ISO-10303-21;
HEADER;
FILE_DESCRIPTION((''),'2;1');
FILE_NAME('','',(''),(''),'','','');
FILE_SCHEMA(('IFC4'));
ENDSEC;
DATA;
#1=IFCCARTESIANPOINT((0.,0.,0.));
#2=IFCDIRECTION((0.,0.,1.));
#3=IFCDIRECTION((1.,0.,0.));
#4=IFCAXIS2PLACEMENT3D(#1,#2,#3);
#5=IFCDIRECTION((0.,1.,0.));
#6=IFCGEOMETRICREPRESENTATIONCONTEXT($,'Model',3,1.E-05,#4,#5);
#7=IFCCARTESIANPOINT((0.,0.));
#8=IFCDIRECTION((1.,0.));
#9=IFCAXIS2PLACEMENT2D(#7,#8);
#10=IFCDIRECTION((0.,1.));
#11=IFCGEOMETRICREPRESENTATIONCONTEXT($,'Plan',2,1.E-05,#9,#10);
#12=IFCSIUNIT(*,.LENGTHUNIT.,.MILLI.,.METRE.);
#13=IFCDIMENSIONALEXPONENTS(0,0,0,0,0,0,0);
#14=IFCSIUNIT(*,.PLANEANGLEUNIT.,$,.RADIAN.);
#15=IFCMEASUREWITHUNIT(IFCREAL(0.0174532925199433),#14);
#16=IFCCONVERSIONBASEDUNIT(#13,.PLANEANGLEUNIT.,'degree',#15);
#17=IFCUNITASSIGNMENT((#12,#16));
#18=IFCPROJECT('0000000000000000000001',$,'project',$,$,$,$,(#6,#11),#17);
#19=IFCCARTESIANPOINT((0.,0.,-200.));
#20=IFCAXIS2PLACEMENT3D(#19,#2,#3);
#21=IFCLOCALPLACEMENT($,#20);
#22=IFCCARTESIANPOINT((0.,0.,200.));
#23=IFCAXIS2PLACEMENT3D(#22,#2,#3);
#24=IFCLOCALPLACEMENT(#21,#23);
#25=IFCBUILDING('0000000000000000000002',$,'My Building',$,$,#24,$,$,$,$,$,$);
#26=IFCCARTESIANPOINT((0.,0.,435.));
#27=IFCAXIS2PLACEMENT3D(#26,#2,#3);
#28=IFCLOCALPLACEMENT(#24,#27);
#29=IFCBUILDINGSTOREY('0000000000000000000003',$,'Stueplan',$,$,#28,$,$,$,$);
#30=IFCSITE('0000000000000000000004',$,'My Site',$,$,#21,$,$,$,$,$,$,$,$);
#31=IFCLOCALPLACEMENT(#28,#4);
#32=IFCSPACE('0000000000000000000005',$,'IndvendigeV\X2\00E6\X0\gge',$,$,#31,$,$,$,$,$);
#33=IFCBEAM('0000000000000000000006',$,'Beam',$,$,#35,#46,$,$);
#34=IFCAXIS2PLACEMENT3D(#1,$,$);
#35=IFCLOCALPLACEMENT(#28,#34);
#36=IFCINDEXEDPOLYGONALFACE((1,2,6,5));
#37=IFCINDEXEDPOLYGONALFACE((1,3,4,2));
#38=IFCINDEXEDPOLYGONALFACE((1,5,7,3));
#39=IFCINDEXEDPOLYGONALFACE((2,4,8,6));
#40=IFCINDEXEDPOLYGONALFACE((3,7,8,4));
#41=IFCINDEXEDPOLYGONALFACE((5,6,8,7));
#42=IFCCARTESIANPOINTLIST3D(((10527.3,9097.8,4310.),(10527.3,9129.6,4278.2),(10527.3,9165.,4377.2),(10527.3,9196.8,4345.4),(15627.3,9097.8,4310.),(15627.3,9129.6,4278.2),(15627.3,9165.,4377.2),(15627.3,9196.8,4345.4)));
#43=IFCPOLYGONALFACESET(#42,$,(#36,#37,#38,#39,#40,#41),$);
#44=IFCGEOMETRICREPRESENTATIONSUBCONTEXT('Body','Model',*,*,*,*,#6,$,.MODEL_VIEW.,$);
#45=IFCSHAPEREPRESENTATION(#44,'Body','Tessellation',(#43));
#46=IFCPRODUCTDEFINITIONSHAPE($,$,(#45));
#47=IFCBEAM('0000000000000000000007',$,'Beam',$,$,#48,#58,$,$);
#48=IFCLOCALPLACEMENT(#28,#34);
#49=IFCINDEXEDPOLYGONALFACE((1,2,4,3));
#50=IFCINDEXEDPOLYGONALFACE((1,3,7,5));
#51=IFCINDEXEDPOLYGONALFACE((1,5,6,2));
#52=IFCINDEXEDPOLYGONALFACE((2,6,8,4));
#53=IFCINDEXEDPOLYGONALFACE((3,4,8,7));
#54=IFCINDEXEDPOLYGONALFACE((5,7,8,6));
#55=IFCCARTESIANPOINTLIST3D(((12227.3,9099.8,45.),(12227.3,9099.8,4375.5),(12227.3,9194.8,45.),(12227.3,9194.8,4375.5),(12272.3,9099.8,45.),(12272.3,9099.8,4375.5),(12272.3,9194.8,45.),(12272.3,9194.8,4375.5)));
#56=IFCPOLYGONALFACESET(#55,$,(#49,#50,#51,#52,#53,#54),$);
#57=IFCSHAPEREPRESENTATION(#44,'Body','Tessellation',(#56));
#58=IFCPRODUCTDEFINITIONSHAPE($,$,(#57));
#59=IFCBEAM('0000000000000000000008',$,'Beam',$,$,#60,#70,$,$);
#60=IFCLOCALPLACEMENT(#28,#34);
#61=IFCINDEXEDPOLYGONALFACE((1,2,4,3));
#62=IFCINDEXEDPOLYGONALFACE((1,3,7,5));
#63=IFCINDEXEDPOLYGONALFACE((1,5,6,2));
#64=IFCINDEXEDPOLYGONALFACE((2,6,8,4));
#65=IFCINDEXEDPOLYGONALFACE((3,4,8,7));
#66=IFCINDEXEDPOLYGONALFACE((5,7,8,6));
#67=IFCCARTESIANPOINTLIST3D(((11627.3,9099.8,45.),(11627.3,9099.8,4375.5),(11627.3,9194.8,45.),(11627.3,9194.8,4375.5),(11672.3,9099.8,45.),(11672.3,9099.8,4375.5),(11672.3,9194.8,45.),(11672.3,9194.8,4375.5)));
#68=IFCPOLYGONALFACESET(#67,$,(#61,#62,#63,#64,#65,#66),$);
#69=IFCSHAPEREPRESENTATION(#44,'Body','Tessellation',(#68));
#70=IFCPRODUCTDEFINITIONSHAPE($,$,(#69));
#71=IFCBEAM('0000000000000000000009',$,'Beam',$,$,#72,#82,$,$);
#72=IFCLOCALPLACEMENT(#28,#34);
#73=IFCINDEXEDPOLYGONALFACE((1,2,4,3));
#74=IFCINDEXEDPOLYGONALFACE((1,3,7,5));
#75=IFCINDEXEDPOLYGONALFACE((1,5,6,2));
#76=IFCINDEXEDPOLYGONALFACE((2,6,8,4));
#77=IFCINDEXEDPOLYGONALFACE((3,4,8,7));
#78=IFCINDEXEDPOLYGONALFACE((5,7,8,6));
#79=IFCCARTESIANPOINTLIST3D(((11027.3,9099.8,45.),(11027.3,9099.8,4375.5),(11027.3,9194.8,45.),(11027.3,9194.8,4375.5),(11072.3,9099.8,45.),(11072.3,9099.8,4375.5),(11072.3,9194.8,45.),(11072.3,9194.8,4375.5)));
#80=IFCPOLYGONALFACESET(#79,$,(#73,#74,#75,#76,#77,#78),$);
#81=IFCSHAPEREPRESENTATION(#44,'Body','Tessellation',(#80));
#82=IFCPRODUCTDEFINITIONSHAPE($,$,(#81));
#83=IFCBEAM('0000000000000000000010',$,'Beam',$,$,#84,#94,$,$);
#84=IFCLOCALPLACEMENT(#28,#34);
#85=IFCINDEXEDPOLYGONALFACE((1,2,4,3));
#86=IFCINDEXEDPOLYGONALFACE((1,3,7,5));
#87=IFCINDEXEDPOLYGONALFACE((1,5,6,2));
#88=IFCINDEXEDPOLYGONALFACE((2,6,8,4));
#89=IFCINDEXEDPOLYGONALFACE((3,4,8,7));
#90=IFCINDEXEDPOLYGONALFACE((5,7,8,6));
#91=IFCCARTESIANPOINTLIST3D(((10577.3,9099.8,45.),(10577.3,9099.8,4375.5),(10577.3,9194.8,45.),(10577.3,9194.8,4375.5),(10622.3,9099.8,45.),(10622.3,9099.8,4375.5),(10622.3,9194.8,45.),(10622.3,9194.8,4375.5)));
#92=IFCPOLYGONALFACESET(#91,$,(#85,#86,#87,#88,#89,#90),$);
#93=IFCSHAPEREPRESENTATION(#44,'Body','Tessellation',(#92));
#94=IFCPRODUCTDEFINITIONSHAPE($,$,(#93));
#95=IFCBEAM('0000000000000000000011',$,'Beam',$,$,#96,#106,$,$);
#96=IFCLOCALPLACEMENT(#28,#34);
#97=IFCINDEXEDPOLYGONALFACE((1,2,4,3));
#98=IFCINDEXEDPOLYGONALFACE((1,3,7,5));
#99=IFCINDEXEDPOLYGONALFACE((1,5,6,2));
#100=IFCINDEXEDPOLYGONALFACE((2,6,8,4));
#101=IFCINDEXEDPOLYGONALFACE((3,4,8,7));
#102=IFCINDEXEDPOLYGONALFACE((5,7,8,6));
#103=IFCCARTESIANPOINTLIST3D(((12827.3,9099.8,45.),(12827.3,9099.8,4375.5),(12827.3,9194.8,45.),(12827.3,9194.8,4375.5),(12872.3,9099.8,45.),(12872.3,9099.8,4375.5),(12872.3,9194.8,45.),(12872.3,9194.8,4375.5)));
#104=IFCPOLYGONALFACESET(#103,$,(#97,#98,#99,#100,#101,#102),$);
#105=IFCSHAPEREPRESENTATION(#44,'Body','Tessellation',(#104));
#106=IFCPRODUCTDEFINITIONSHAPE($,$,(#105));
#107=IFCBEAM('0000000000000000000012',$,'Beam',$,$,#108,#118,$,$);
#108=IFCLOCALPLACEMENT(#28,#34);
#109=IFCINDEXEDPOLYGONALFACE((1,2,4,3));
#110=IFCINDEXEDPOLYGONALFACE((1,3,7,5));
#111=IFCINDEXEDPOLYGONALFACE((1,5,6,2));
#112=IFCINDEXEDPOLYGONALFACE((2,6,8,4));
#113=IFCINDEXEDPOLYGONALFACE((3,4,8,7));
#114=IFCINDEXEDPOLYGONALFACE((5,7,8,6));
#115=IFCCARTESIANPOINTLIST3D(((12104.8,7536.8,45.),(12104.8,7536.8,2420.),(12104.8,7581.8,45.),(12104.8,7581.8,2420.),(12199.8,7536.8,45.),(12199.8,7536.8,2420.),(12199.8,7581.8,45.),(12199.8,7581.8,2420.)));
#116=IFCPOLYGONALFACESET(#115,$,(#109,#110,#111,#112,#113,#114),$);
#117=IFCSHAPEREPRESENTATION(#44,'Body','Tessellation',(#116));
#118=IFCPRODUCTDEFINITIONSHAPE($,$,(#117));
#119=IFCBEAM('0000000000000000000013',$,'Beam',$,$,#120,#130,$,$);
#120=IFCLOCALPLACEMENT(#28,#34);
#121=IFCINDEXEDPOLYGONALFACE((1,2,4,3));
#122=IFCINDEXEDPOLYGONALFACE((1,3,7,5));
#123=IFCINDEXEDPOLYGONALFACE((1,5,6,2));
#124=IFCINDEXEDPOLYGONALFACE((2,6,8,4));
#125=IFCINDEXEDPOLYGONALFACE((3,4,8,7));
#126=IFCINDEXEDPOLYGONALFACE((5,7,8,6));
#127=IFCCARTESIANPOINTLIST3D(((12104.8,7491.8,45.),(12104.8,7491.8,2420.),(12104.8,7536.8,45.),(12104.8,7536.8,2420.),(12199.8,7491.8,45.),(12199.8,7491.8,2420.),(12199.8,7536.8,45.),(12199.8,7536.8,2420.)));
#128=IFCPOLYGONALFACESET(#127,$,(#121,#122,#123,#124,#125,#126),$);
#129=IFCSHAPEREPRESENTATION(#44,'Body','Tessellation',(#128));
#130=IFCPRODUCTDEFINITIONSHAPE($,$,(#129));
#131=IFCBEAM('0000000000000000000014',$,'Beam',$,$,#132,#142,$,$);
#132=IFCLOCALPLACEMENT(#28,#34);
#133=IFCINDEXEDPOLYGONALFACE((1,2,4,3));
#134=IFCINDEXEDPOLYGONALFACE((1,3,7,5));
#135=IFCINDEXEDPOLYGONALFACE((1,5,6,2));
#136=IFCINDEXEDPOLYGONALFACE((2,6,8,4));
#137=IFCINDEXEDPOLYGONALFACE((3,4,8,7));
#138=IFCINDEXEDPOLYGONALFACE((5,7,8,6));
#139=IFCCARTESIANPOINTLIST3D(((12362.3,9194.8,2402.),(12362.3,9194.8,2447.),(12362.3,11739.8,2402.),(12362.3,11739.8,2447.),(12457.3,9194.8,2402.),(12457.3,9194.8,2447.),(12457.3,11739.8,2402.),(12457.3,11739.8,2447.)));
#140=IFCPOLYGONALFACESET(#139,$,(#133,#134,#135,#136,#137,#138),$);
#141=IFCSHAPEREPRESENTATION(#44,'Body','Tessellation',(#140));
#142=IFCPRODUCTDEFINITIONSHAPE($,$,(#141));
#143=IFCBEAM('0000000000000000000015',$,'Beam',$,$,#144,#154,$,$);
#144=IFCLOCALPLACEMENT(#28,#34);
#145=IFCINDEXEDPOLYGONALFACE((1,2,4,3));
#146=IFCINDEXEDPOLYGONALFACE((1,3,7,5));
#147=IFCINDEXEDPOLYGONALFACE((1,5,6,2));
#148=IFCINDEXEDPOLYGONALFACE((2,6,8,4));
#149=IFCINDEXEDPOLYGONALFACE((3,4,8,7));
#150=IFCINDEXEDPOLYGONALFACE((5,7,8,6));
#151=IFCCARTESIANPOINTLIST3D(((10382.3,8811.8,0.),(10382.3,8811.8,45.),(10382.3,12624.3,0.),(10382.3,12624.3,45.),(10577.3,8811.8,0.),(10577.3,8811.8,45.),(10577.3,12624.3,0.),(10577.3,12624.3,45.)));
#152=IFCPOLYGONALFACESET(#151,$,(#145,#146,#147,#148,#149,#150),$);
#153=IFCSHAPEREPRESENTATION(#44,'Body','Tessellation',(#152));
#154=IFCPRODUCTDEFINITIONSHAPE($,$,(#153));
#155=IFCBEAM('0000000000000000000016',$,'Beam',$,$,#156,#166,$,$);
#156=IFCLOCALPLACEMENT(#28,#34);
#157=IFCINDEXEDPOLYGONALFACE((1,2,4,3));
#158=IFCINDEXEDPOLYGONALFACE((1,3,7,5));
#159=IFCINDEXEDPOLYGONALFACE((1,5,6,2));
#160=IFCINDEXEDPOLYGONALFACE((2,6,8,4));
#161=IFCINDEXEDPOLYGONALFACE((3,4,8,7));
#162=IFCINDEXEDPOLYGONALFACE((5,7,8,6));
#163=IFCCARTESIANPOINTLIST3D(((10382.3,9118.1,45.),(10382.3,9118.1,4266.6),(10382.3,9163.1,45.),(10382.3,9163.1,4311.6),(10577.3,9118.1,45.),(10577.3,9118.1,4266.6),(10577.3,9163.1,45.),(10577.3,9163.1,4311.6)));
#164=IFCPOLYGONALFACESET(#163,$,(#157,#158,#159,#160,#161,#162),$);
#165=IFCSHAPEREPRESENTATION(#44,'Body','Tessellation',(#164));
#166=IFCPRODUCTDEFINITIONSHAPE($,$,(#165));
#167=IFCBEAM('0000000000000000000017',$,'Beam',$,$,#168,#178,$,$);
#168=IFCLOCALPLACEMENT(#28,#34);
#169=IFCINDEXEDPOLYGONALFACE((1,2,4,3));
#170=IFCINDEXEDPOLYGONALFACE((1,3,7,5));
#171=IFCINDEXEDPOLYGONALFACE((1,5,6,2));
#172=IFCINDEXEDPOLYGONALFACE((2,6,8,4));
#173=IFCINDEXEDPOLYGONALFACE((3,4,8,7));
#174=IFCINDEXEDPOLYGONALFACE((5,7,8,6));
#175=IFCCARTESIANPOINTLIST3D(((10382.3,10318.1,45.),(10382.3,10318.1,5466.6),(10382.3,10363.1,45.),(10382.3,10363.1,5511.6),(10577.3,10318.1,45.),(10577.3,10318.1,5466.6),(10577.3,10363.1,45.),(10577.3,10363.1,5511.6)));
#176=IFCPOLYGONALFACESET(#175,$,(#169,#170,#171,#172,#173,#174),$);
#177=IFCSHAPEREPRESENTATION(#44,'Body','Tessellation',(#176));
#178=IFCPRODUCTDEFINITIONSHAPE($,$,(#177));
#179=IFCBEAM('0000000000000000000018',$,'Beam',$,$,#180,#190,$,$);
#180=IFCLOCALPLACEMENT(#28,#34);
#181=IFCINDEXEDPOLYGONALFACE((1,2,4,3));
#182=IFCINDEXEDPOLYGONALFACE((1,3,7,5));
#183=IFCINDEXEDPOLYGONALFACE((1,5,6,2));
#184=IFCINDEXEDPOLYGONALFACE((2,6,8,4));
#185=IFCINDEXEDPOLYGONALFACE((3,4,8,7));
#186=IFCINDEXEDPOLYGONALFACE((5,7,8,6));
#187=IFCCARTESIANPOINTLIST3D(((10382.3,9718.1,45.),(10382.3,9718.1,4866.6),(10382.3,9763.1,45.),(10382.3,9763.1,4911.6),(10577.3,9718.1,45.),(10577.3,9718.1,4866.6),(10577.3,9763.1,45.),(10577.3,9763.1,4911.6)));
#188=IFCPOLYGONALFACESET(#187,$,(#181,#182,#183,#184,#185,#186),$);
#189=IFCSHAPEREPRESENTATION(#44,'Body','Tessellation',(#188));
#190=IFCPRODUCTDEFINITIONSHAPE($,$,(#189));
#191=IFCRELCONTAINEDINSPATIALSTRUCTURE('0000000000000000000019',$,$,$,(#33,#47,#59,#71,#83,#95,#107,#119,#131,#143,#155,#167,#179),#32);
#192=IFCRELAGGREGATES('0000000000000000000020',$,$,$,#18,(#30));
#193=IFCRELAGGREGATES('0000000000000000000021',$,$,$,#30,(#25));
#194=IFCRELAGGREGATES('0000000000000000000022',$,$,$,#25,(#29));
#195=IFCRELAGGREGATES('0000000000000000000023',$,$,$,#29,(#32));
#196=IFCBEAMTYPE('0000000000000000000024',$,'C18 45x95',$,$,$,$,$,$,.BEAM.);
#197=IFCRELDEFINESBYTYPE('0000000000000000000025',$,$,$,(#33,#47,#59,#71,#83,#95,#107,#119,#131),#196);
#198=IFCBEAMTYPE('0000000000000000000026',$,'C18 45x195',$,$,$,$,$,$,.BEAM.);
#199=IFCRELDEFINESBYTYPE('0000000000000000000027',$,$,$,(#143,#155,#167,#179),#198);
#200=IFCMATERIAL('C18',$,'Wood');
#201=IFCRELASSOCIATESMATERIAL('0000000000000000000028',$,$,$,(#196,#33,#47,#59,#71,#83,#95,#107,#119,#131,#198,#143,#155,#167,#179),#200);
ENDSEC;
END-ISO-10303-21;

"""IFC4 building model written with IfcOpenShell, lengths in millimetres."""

from ifc_helpers import new_model, entity, si_unit, converted_unit, direction, frame, origin_with_axes, origin_2d_with_axis, place, context, subcontext, project, spatial, rectangle, extrude, clip, halfspace, material, material_profile, profile_set, profile_usage, type_object, element, save


model = new_model("IFC4")

# Units and contexts
model_context = context("Model", 3, precision=1e-05, world=origin_with_axes(), true_north=direction((0.0, 1.0, 0.0)))
plan_context = context("Plan", 2, precision=1e-05, world=origin_2d_with_axis(), true_north=direction((0.0, 1.0)))
body_context_1 = subcontext(model_context, "Body", "Model", "MODEL_VIEW")
ifc_project = project(units=[si_unit("LENGTHUNIT", "METRE", prefix="MILLI"), converted_unit("PLANEANGLEUNIT", "degree", entity("IfcReal", 0.0174532925199433), si_unit("PLANEANGLEUNIT", "RADIAN"), dimensions=[0, 0, 0, 0, 0, 0, 0])], contexts=[model_context, plan_context])

# Site, building, storey
site_placement = place(None, frame((0.0, 0.0, -200.0), z_axis=(0.0, 0.0, 1.0), x_axis=(1.0, 0.0, 0.0)))
site = spatial("IfcSite", under=ifc_project, at=site_placement, Name="My Site")
building_placement = place(site_placement, frame((0.0, 0.0, 200.0), z_axis=(0.0, 0.0, 1.0), x_axis=(1.0, 0.0, 0.0)))
building = spatial("IfcBuilding", under=site, at=building_placement, Name="My Building")
storey_placement = place(building_placement, frame((0.0, 0.0, 435.0), z_axis=(0.0, 0.0, 1.0), x_axis=(1.0, 0.0, 0.0)))
storey = spatial("IfcBuildingStorey", under=building, at=storey_placement, Name="Stueplan")

# Shared definitions
ifc_material = material(Name="C18", Category="Wood")

# Shared definitions
space_1_placement = place(storey_placement, frame((0.0, 0.0, 0.0), z_axis=(0.0, 0.0, 1.0), x_axis=(1.0, 0.0, 0.0)))
space_1 = spatial("IfcSpace", under=storey, at=space_1_placement, Name="IndvendigeVægge")

# Beams
ifc_material_profile_1 = material_profile(ifc_material, rectangle(XDim=45.0, YDim=95.0))
ifc_profile_set_1 = profile_set([ifc_material_profile_1], Name="woodStructural")
beam_type_1 = type_object("IfcBeamType", Name="C18 45x95", PredefinedType="BEAM", material=ifc_profile_set_1)
ifc_profile_usage_1 = profile_usage(ifc_profile_set_1, cardinal=5)
beam_1_placement = place(space_1_placement, frame((10527.3, 9147.3, 4327.7), z_axis=(1.0, 0.0, 0.0), x_axis=(0.0, -0.707107, 0.707107)))
element("IfcBeam", 1, at=beam_1_placement, inside=space_1, type_object=beam_type_1, material=ifc_profile_usage_1, Name="Beam", context=body_context_1, shape_type="SweptSolid", body=[
    extrude(rectangle(XDim=45.0, YDim=95.0), origin_with_axes(), (0.0, 0.0, 1.0), 5100.0),
])
ifc_profile_usage_2 = profile_usage(ifc_profile_set_1)
beam_2_placement = place(space_1_placement, frame((12249.8, 9147.3, 45.0), z_axis=(0.0, 0.0, 1.0), x_axis=(-1.0, 0.0, 0.0)))
element("IfcBeam", 2, at=beam_2_placement, inside=space_1, type_object=beam_type_1, material=ifc_profile_usage_2, Name="Beam", context=body_context_1, shape_type="SweptSolid", body=[
    extrude(rectangle(XDim=45.0, YDim=95.0), origin_with_axes(), (0.0, 0.0, 1.0), 4330.5),
])
ifc_profile_usage_3 = profile_usage(ifc_profile_set_1)
beam_3_placement = place(space_1_placement, frame((11649.8, 9147.3, 45.0), z_axis=(0.0, 0.0, 1.0), x_axis=(-1.0, 0.0, 0.0)))
element("IfcBeam", 3, at=beam_3_placement, inside=space_1, type_object=beam_type_1, material=ifc_profile_usage_3, Name="Beam", context=body_context_1, shape_type="SweptSolid", body=[
    extrude(rectangle(XDim=45.0, YDim=95.0), origin_with_axes(), (0.0, 0.0, 1.0), 4330.5),
])
ifc_profile_usage_4 = profile_usage(ifc_profile_set_1)
beam_4_placement = place(space_1_placement, frame((11049.8, 9147.3, 45.0), z_axis=(0.0, 0.0, 1.0), x_axis=(-1.0, 0.0, 0.0)))
element("IfcBeam", 4, at=beam_4_placement, inside=space_1, type_object=beam_type_1, material=ifc_profile_usage_4, Name="Beam", context=body_context_1, shape_type="SweptSolid", body=[
    extrude(rectangle(XDim=45.0, YDim=95.0), origin_with_axes(), (0.0, 0.0, 1.0), 4330.5),
])
ifc_profile_usage_5 = profile_usage(ifc_profile_set_1)
beam_5_placement = place(space_1_placement, frame((10599.8, 9147.3, 45.0), z_axis=(0.0, 0.0, 1.0), x_axis=(-1.0, 0.0, 0.0)))
element("IfcBeam", 5, at=beam_5_placement, inside=space_1, type_object=beam_type_1, material=ifc_profile_usage_5, Name="Beam", context=body_context_1, shape_type="SweptSolid", body=[
    extrude(rectangle(XDim=45.0, YDim=95.0), origin_with_axes(), (0.0, 0.0, 1.0), 4330.5),
])
ifc_profile_usage_6 = profile_usage(ifc_profile_set_1)
beam_6_placement = place(space_1_placement, frame((12849.8, 9147.3, 45.0), z_axis=(0.0, 0.0, 1.0), x_axis=(-1.0, 0.0, 0.0)))
element("IfcBeam", 6, at=beam_6_placement, inside=space_1, type_object=beam_type_1, material=ifc_profile_usage_6, Name="Beam", context=body_context_1, shape_type="SweptSolid", body=[
    extrude(rectangle(XDim=45.0, YDim=95.0), origin_with_axes(), (0.0, 0.0, 1.0), 4330.5),
])
ifc_profile_usage_7 = profile_usage(ifc_profile_set_1)
beam_7_placement = place(space_1_placement, frame((12152.3, 7559.3, 45.0), z_axis=(0.0, 0.0, 1.0), x_axis=(0.0, 1.0, 0.0)))
element("IfcBeam", 7, at=beam_7_placement, inside=space_1, type_object=beam_type_1, material=ifc_profile_usage_7, Name="Beam", context=body_context_1, shape_type="SweptSolid", body=[
    extrude(rectangle(XDim=45.0, YDim=95.0), origin_with_axes(), (0.0, 0.0, 1.0), 2375.0),
])
ifc_profile_usage_8 = profile_usage(ifc_profile_set_1)
beam_8_placement = place(space_1_placement, frame((12152.3, 7514.3, 45.0), z_axis=(0.0, 0.0, 1.0), x_axis=(0.0, 1.0, 0.0)))
element("IfcBeam", 8, at=beam_8_placement, inside=space_1, type_object=beam_type_1, material=ifc_profile_usage_8, Name="Beam", context=body_context_1, shape_type="SweptSolid", body=[
    extrude(rectangle(XDim=45.0, YDim=95.0), origin_with_axes(), (0.0, 0.0, 1.0), 2375.0),
])
ifc_profile_usage_9 = profile_usage(ifc_profile_set_1, cardinal=5)
beam_9_placement = place(space_1_placement, frame((12409.8, 9194.8, 2424.5), z_axis=(0.0, 1.0, 0.0), x_axis=(0.0, 0.0, 1.0)))
element("IfcBeam", 9, at=beam_9_placement, inside=space_1, type_object=beam_type_1, material=ifc_profile_usage_9, Name="Beam", context=body_context_1, shape_type="SweptSolid", body=[
    extrude(rectangle(XDim=45.0, YDim=95.0), origin_with_axes(), (0.0, 0.0, 1.0), 2545.0),
])
ifc_material_profile_2 = material_profile(ifc_material, rectangle(XDim=45.0, YDim=195.0))
ifc_profile_set_2 = profile_set([ifc_material_profile_2], Name="woodStructural")
ifc_profile_usage_10 = profile_usage(ifc_profile_set_2)
beam_type_2 = type_object("IfcBeamType", Name="C18 45x195", PredefinedType="BEAM", material=ifc_profile_set_2)
beam_10_placement = place(space_1_placement, frame((10479.8, 8811.8, 22.5), z_axis=(0.0, 1.0, 0.0), x_axis=(0.0, 0.0, 1.0)))
element("IfcBeam", 10, at=beam_10_placement, inside=space_1, type_object=beam_type_2, material=ifc_profile_usage_10, Name="Beam", context=body_context_1, shape_type="SweptSolid", body=[
    extrude(rectangle(XDim=45.0, YDim=195.0), origin_with_axes(), (0.0, 0.0, 1.0), 3812.5),
])
ifc_profile_usage_11 = profile_usage(ifc_profile_set_2)
beam_11_placement = place(space_1_placement, frame((10479.8, 9140.6, 45.0), z_axis=(0.0, 0.0, 1.0), x_axis=(0.0, 1.0, 0.0)))
element("IfcBeam", 11, at=beam_11_placement, inside=space_1, type_object=beam_type_2, material=ifc_profile_usage_11, Name="Beam", context=body_context_1, shape_type="Clipping", body=[
    clip(extrude(rectangle(XDim=45.0, YDim=195.0), origin_with_axes(), (0.0, 0.0, 1.0), 4439.1), halfspace(frame((-1635.7, 0.0, 2608.4), z_axis=(-0.707107, 0.0, 0.707107), x_axis=(0.0, 1.0, 0.0)), False)),
])
ifc_profile_usage_12 = profile_usage(ifc_profile_set_2)
beam_12_placement = place(space_1_placement, frame((10479.8, 10340.6, 45.0), z_axis=(0.0, 0.0, 1.0), x_axis=(0.0, 1.0, 0.0)))
element("IfcBeam", 12, at=beam_12_placement, inside=space_1, type_object=beam_type_2, material=ifc_profile_usage_12, Name="Beam", context=body_context_1, shape_type="Clipping", body=[
    clip(extrude(rectangle(XDim=45.0, YDim=195.0), origin_with_axes(), (0.0, 0.0, 1.0), 5639.1), halfspace(frame((-2835.7, 0.0, 2608.4), z_axis=(-0.707107, 0.0, 0.707107), x_axis=(0.0, 1.0, 0.0)), False)),
])
ifc_profile_usage_13 = profile_usage(ifc_profile_set_2)
beam_13_placement = place(space_1_placement, frame((10479.8, 9740.6, 45.0), z_axis=(0.0, 0.0, 1.0), x_axis=(0.0, 1.0, 0.0)))
element("IfcBeam", 13, at=beam_13_placement, inside=space_1, type_object=beam_type_2, material=ifc_profile_usage_13, Name="Beam", context=body_context_1, shape_type="Clipping", body=[
    clip(extrude(rectangle(XDim=45.0, YDim=195.0), origin_with_axes(), (0.0, 0.0, 1.0), 5039.1), halfspace(frame((-2235.7, 0.0, 2608.4), z_axis=(-0.707107, 0.0, 0.707107), x_axis=(0.0, 1.0, 0.0)), False)),
])

save(model, "model.ifc")
